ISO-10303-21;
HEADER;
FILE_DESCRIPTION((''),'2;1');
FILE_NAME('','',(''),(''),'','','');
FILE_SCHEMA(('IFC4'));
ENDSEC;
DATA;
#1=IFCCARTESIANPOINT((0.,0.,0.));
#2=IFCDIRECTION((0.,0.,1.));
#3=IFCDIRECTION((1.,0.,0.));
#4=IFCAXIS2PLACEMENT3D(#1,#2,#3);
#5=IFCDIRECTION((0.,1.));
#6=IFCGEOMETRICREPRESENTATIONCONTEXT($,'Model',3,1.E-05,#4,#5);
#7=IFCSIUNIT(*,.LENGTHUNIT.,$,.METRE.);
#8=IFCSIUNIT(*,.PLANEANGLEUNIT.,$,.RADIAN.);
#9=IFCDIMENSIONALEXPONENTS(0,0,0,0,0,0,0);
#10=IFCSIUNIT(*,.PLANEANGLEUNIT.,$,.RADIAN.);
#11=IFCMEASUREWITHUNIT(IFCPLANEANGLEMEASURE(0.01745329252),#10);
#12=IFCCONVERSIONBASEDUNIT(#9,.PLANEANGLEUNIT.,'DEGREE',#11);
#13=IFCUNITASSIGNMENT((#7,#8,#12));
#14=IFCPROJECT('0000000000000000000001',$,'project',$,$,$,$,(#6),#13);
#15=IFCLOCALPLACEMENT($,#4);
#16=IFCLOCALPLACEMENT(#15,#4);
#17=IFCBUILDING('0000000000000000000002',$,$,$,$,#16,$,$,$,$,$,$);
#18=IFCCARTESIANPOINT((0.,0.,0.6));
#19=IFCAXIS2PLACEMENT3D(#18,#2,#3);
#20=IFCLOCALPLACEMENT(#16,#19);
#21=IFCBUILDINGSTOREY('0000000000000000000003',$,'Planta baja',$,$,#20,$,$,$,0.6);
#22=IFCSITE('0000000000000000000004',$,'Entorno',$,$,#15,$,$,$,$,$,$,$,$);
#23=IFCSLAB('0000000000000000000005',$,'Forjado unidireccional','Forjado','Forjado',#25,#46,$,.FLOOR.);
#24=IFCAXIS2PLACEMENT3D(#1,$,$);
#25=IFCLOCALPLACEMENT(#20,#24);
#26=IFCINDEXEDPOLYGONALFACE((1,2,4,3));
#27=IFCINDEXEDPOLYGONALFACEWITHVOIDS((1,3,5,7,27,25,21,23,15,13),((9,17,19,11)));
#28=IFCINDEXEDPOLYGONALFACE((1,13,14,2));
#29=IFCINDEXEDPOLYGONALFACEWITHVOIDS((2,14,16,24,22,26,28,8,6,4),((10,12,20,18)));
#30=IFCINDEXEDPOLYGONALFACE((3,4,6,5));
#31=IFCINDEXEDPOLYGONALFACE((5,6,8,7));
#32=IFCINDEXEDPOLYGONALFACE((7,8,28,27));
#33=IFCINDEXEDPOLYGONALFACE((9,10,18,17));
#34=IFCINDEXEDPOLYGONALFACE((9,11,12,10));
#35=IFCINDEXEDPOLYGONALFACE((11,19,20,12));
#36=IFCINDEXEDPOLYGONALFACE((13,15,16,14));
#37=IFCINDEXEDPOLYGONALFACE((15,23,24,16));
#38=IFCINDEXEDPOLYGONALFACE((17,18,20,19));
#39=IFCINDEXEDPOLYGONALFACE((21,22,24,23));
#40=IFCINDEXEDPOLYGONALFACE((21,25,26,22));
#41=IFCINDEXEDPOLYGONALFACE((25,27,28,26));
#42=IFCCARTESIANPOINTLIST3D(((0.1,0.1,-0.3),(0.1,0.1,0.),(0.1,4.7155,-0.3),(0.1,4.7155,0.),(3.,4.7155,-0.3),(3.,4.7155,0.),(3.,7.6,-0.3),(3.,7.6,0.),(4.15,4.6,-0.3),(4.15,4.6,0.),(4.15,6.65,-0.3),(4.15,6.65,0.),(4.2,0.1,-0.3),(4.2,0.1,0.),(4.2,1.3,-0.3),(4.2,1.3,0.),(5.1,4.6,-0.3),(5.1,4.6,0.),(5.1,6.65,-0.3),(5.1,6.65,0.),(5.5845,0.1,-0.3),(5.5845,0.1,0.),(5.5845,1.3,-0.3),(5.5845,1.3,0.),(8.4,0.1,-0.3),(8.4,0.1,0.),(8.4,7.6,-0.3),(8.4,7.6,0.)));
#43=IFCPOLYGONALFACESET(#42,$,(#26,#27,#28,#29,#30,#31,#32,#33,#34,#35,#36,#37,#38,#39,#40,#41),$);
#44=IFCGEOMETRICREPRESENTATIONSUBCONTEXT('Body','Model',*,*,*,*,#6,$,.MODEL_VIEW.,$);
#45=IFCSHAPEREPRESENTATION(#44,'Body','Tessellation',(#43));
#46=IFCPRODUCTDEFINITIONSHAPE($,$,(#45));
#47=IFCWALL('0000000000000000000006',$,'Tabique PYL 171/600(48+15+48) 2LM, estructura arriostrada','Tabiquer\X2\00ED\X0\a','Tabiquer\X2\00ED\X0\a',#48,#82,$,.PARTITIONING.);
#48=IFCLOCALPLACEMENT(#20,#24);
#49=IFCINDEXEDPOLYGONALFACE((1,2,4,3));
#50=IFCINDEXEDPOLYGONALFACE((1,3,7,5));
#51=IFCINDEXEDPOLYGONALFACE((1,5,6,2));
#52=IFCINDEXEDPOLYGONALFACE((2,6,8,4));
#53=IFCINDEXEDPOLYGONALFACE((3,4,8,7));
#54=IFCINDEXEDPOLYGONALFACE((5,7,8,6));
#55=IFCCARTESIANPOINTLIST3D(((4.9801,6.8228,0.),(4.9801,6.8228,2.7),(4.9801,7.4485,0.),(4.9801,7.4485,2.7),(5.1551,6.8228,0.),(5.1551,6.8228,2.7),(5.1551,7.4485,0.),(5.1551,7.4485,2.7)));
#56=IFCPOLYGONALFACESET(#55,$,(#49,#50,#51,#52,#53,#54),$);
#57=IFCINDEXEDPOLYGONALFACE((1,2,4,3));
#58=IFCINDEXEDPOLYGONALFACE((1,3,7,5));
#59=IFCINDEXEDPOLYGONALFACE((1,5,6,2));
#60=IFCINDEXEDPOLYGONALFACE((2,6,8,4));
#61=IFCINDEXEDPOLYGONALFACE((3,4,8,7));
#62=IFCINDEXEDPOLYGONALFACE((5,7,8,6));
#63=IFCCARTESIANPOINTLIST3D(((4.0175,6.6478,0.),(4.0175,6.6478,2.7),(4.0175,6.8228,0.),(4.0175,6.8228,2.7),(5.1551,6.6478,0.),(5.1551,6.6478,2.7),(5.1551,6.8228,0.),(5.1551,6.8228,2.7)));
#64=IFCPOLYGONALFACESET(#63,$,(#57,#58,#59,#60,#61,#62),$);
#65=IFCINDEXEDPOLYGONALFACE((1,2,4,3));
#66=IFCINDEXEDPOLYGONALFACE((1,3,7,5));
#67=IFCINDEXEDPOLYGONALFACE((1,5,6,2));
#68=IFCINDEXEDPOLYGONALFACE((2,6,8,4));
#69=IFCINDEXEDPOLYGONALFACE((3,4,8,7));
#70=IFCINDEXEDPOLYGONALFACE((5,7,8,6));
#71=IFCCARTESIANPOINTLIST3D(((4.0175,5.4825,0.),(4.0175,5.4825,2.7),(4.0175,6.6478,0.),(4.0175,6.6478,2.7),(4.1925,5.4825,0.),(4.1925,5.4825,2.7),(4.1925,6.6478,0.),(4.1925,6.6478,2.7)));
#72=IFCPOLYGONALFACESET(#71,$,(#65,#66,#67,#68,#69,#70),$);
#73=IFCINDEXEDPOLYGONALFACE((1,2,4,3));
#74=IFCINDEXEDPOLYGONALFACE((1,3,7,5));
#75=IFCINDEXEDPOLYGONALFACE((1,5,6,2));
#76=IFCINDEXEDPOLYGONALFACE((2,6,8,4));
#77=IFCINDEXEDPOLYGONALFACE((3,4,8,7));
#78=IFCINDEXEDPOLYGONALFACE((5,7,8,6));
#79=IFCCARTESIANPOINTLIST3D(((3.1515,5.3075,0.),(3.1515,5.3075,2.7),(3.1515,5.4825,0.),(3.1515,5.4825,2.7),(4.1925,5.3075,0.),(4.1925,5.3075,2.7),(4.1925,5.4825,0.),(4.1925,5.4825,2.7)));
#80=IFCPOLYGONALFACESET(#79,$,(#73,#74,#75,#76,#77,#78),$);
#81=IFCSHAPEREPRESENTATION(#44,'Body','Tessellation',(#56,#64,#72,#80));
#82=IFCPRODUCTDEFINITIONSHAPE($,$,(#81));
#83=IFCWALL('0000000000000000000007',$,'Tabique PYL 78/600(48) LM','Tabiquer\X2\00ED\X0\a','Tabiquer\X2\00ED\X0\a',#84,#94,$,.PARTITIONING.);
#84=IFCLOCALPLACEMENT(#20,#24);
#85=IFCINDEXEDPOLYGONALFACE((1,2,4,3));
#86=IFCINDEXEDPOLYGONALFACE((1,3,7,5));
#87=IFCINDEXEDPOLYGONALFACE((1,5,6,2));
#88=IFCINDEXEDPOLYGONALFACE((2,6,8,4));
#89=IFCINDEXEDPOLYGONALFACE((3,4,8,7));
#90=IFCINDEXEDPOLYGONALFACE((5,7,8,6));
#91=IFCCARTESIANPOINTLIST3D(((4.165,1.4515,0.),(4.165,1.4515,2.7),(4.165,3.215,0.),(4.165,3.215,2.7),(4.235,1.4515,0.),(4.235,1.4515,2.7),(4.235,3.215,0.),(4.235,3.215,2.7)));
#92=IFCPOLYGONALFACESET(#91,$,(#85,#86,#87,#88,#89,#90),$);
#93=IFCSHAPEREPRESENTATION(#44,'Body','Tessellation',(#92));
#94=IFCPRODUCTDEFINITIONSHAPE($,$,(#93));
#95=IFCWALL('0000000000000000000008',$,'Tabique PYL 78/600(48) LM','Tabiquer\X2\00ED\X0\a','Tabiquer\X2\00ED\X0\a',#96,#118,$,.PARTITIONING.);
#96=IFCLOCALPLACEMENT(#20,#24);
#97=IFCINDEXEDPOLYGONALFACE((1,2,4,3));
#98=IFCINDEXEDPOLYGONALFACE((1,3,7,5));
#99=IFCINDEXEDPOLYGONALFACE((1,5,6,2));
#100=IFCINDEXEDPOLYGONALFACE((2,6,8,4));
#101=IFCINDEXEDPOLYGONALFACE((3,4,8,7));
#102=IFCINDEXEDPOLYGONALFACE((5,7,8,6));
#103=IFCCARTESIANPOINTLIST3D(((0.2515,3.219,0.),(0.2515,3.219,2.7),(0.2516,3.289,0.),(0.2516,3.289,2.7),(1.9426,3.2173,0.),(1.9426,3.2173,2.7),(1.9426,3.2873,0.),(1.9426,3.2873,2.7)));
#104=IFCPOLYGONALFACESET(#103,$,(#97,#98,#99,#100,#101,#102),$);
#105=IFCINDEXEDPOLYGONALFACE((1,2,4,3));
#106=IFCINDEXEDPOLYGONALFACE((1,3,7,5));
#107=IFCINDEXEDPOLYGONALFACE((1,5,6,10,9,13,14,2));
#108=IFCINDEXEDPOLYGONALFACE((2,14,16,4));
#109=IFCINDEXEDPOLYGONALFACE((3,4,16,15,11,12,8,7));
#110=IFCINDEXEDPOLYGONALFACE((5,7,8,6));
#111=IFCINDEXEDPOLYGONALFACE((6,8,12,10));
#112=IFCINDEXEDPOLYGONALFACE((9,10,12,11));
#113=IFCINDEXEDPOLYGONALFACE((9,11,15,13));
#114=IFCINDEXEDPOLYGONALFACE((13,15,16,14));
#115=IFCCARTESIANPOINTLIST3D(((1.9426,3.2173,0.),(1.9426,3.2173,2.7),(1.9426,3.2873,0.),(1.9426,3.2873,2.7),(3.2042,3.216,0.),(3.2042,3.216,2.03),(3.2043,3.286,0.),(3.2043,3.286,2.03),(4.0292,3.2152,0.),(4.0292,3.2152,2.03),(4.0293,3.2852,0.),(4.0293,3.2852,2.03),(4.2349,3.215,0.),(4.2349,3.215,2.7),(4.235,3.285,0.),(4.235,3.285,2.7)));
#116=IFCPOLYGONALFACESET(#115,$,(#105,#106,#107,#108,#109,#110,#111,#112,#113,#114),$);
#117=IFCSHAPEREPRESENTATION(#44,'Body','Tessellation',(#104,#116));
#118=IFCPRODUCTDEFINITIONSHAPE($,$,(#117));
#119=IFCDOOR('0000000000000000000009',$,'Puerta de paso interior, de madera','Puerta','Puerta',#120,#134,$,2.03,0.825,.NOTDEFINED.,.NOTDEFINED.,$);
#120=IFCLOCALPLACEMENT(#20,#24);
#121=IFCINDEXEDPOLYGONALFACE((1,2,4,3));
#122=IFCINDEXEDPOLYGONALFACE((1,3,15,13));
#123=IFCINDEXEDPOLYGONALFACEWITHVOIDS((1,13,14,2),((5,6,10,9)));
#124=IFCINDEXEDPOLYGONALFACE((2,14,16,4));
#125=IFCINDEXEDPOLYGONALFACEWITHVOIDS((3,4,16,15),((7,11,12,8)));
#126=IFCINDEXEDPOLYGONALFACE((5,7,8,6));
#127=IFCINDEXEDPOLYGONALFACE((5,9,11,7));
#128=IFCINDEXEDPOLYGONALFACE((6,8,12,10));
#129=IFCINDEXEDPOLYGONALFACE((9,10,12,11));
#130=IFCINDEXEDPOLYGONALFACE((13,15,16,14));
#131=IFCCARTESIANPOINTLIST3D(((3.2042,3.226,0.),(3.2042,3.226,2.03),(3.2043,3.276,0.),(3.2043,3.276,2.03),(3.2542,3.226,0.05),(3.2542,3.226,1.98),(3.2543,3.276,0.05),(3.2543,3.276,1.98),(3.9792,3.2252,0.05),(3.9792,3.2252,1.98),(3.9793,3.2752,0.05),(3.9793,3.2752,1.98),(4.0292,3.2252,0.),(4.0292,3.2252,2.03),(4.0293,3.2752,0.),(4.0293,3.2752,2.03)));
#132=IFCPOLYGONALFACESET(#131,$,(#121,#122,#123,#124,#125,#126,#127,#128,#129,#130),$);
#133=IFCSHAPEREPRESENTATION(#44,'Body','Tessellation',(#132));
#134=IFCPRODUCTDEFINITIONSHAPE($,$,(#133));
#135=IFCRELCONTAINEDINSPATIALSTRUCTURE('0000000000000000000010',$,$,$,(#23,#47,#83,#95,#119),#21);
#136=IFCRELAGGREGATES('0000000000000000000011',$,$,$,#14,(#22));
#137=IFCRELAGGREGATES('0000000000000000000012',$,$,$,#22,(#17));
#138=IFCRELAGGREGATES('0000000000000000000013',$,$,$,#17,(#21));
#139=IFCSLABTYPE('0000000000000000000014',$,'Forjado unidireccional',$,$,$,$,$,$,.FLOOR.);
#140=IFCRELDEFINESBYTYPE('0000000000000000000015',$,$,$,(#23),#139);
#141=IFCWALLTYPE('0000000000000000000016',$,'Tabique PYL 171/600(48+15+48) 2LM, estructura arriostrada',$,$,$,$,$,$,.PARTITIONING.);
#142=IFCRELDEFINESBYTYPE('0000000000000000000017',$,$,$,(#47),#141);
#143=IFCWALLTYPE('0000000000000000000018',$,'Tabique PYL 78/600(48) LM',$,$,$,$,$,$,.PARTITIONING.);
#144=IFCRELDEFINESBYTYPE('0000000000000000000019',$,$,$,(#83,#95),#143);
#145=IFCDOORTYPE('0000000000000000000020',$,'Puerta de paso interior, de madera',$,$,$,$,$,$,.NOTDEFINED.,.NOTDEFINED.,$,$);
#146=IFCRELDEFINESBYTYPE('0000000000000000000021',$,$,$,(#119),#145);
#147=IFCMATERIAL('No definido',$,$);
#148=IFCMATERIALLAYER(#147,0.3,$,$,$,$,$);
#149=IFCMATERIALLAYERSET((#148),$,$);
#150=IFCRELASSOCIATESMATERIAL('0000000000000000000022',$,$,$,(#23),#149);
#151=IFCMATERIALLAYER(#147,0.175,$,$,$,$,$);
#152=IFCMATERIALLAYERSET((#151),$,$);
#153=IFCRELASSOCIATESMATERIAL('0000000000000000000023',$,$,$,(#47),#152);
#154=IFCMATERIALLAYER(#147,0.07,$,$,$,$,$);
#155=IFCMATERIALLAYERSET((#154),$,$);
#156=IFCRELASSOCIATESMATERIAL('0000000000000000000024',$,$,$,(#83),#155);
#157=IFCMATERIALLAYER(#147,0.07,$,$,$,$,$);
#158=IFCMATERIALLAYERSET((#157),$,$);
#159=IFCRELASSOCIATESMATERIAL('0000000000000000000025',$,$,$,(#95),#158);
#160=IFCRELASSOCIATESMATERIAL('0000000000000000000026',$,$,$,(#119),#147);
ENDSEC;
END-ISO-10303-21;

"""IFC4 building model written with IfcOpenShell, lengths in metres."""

from ifc_helpers import new_model, entity, si_unit, converted_unit, direction, frame, origin_with_axes, origin_2d_with_axis, place, context, subcontext, project, spatial, polyline, rectangle, hollow_rectangle, outline, extrude, shape, material, layer, layer_set, layer_usage, type_object, element, fill, save


model = new_model("IFC4")

# Units and contexts
model_context = context("Model", 3, precision=1e-05, world=origin_with_axes(), true_north=direction((0.0, 1.0)))
body_context = subcontext(model_context, "Body", "Model", "MODEL_VIEW")
footprint_context = subcontext(model_context, "FootPrint", "Model", "MODEL_VIEW")
ifc_project = project(units=[si_unit("LENGTHUNIT", "METRE"), si_unit("PLANEANGLEUNIT", "RADIAN"), converted_unit("PLANEANGLEUNIT", "DEGREE", entity("IfcPlaneAngleMeasure", 0.01745329252), si_unit("PLANEANGLEUNIT", "RADIAN"), dimensions=[0, 0, 0, 0, 0, 0, 0])], contexts=[model_context])

# Site, building, storey
site_placement = place(None, origin_with_axes())
site = spatial("IfcSite", under=ifc_project, at=site_placement, Name="Entorno")
building_placement = place(site_placement, origin_with_axes())
building = spatial("IfcBuilding", under=site, at=building_placement)
storey_placement = place(building_placement, frame((0.0, 0.0, 0.6), z_axis=(0.0, 0.0, 1.0), x_axis=(1.0, 0.0, 0.0)))
storey = spatial("IfcBuildingStorey", under=building, at=storey_placement, Name="Planta baja", Elevation=0.6)

# Slab, opening
ifc_material = material(Name="No definido")
ifc_layer_1 = layer(ifc_material, 0.3)
ifc_layer_set_1 = layer_set([ifc_layer_1])
ifc_layer_usage_1 = layer_usage(ifc_layer_set_1, "AXIS3", "POSITIVE", 0.0)
slab_type_1 = type_object("IfcSlabType", Name="Forjado unidireccional", PredefinedType="FLOOR")
slab_placement = place(storey_placement, frame((4.2, 0.1, -0.3), z_axis=(0.0, 0.0, 1.0), x_axis=(1.0, 0.0, 0.0)))
slab = element("IfcSlab", 1, at=slab_placement, inside=storey, type_object=slab_type_1, material=ifc_layer_usage_1, Name="Forjado unidireccional", Description="Forjado", ObjectType="Forjado", PredefinedType="FLOOR", context=body_context, shape_type="SweptSolid", body=[
    extrude(outline(polyline([(0.0, 0.0), (0.0, 1.2), (1.3845, 1.2), (1.3845, 0.0), (4.2, 0.0), (4.2, 7.5), (-1.2, 7.5), (-1.2, 4.6155), (-4.1, 4.6155), (-4.1, 0.0), (0.0, 0.0)])), origin_with_axes(), (0.0, 0.0, 1.0), 0.3),
])
opening_1_placement = place(slab_placement, frame((-0.05, 4.5, -0.01), z_axis=(0.0, 0.0, 1.0), x_axis=(1.0, 0.0, 0.0)))
element("IfcOpeningElement", 2, at=opening_1_placement, cuts=slab, ObjectType="No definido", PredefinedType="OPENING", context=body_context, shape_type="SweptSolid", body=[
    extrude(outline(polyline([(0.0, 0.0), (0.95, 0.0), (0.95, 2.05), (0.0, 2.05), (0.0, 0.0)])), origin_with_axes(), (0.0, 0.0, 1.0), 0.32),
])

# Walls
ifc_layer_2 = layer(ifc_material, 0.175)
ifc_layer_set_2 = layer_set([ifc_layer_2])
ifc_layer_usage_2 = layer_usage(ifc_layer_set_2, "AXIS2", "POSITIVE", -0.0875)
wall_type_1 = type_object("IfcWallType", Name="Tabique PYL 171/600(48+15+48) 2LM, estructura arriostrada", PredefinedType="PARTITIONING")
wall_1_placement = place(storey_placement, frame((5.0676, 7.6, 0.0), z_axis=(0.0, 0.0, 1.0), x_axis=(0.0, -1.0, 0.0)))
cartesian_point_1 = entity("IfcCartesianPoint", [-0.3129, -1.35])
cartesian_point_2 = entity("IfcCartesianPoint", [-0.3129, -1.35])
cartesian_point_3 = entity("IfcCartesianPoint", [-0.5688, -1.35])
cartesian_point_4 = entity("IfcCartesianPoint", [-0.5688, -1.35])
cartesian_point_5 = entity("IfcCartesianPoint", [-0.5827, -1.35])
cartesian_point_6 = entity("IfcCartesianPoint", [-0.5827, -1.35])
cartesian_point_7 = entity("IfcCartesianPoint", [-0.5205, -1.35])
cartesian_point_8 = entity("IfcCartesianPoint", [-0.5205, -1.35])
element("IfcWall", 3, at=wall_1_placement, inside=storey, type_object=wall_type_1, material=ifc_layer_usage_2, Name="Tabique PYL 171/600(48+15+48) 2LM, estructura arriostrada", Description="Tabiquería", ObjectType="Tabiquería", PredefinedType="PARTITIONING", context=body_context, shape_type="SolidModel", body=[
    entity("IfcExtrudedAreaSolidTapered", entity("IfcArbitraryClosedProfileDef", "AREA", None, entity("IfcPolyline", [cartesian_point_1, entity("IfcCartesianPoint", [0.3129, -1.35]), entity("IfcCartesianPoint", [0.3129, 1.35]), entity("IfcCartesianPoint", [-0.3129, 1.35]), cartesian_point_1])), entity("IfcAxis2Placement3D", entity("IfcCartesianPoint", [0.4643, 0.0875, 1.35]), entity("IfcDirection", [0.0, -1.0, 0.0]), entity("IfcDirection", [1.0, 0.0, 0.0])), entity("IfcDirection", [0.0, 0.0, 1.0]), 0.175, entity("IfcArbitraryClosedProfileDef", "AREA", None, entity("IfcPolyline", [cartesian_point_2, entity("IfcCartesianPoint", [0.3129, -1.35]), entity("IfcCartesianPoint", [0.3129, 1.35]), entity("IfcCartesianPoint", [-0.3129, 1.35]), cartesian_point_2]))),
    entity("IfcExtrudedAreaSolidTapered", entity("IfcArbitraryClosedProfileDef", "AREA", None, entity("IfcPolyline", [cartesian_point_3, entity("IfcCartesianPoint", [0.5688, -1.35]), entity("IfcCartesianPoint", [0.5688, 1.35]), entity("IfcCartesianPoint", [-0.5688, 1.35]), cartesian_point_3])), entity("IfcAxis2Placement3D", entity("IfcCartesianPoint", [0.9522, -0.4813, 1.35]), entity("IfcDirection", [-1.0, 0.0, 0.0]), entity("IfcDirection", [0.0, -1.0, 0.0])), entity("IfcDirection", [0.0, 0.0, 1.0]), 0.175, entity("IfcArbitraryClosedProfileDef", "AREA", None, entity("IfcPolyline", [cartesian_point_4, entity("IfcCartesianPoint", [0.5688, -1.35]), entity("IfcCartesianPoint", [0.5688, 1.35]), entity("IfcCartesianPoint", [-0.5688, 1.35]), cartesian_point_4]))),
    entity("IfcExtrudedAreaSolidTapered", entity("IfcArbitraryClosedProfileDef", "AREA", None, entity("IfcPolyline", [cartesian_point_5, entity("IfcCartesianPoint", [0.5827, -1.35]), entity("IfcCartesianPoint", [0.5827, 1.35]), entity("IfcCartesianPoint", [-0.5827, 1.35]), cartesian_point_5])), entity("IfcAxis2Placement3D", entity("IfcCartesianPoint", [1.5349, -0.8751, 1.35]), entity("IfcDirection", [0.0, -1.0, 0.0]), entity("IfcDirection", [1.0, 0.0, 0.0])), entity("IfcDirection", [0.0, 0.0, 1.0]), 0.175, entity("IfcArbitraryClosedProfileDef", "AREA", None, entity("IfcPolyline", [cartesian_point_6, entity("IfcCartesianPoint", [0.5827, -1.35]), entity("IfcCartesianPoint", [0.5827, 1.35]), entity("IfcCartesianPoint", [-0.5827, 1.35]), cartesian_point_6]))),
    entity("IfcExtrudedAreaSolidTapered", entity("IfcArbitraryClosedProfileDef", "AREA", None, entity("IfcPolyline", [cartesian_point_7, entity("IfcCartesianPoint", [0.5205, -1.35]), entity("IfcCartesianPoint", [0.5205, 1.35]), entity("IfcCartesianPoint", [-0.5205, 1.35]), cartesian_point_7])), entity("IfcAxis2Placement3D", entity("IfcCartesianPoint", [2.2925, -1.3956, 1.35]), entity("IfcDirection", [-1.0, 0.0, 0.0]), entity("IfcDirection", [0.0, -1.0, 0.0])), entity("IfcDirection", [0.0, 0.0, 1.0]), 0.175, entity("IfcArbitraryClosedProfileDef", "AREA", None, entity("IfcPolyline", [cartesian_point_8, entity("IfcCartesianPoint", [0.5205, -1.35]), entity("IfcCartesianPoint", [0.5205, 1.35]), entity("IfcCartesianPoint", [-0.5205, 1.35]), cartesian_point_8]))),
])
ifc_layer_3 = layer(ifc_material, 0.07)
ifc_layer_set_3 = layer_set([ifc_layer_3])
ifc_layer_usage_3 = layer_usage(ifc_layer_set_3, "AXIS2", "POSITIVE", -0.035)
wall_type_2 = type_object("IfcWallType", Name="Tabique PYL 78/600(48) LM", PredefinedType="PARTITIONING")
wall_2_placement = place(storey_placement, frame((4.2, 1.3, 0.0), z_axis=(0.0, 0.0, 1.0), x_axis=(0.0, 1.0, 0.0)))
cartesian_point_9 = entity("IfcCartesianPoint", [-0.8817, -1.35])
cartesian_point_10 = entity("IfcCartesianPoint", [-0.8817, -1.35])
element("IfcWall", 4, at=wall_2_placement, inside=storey, type_object=wall_type_2, material=ifc_layer_usage_3, Name="Tabique PYL 78/600(48) LM", Description="Tabiquería", ObjectType="Tabiquería", PredefinedType="PARTITIONING", context=body_context, shape_type="SolidModel", body=[
    entity("IfcExtrudedAreaSolidTapered", entity("IfcArbitraryClosedProfileDef", "AREA", None, entity("IfcPolyline", [cartesian_point_9, entity("IfcCartesianPoint", [0.8817, -1.35]), entity("IfcCartesianPoint", [0.8817, 1.35]), entity("IfcCartesianPoint", [-0.8817, 1.35]), cartesian_point_9])), entity("IfcAxis2Placement3D", entity("IfcCartesianPoint", [1.0332, 0.035, 1.35]), entity("IfcDirection", [0.0, -1.0, 0.0]), entity("IfcDirection", [1.0, 0.0, 0.0])), entity("IfcDirection", [0.0, 0.0, 1.0]), 0.07, entity("IfcArbitraryClosedProfileDef", "AREA", None, entity("IfcPolyline", [cartesian_point_10, entity("IfcCartesianPoint", [0.8817, -1.35]), entity("IfcCartesianPoint", [0.8817, 1.35]), entity("IfcCartesianPoint", [-0.8817, 1.35]), cartesian_point_10]))),
])

# Wall, opening, door
ifc_layer_4 = layer(ifc_material, 0.07)
ifc_layer_set_4 = layer_set([ifc_layer_4])
ifc_layer_usage_4 = layer_usage(ifc_layer_set_4, "AXIS2", "POSITIVE", -0.035)
wall_3_placement = place(storey_placement, frame((0.1, 3.2542, 0.0), z_axis=(0.0, 0.0, 1.0), x_axis=(0.999999, -0.001016, 0.0)))
cartesian_point_11 = entity("IfcCartesianPoint", [-0.8455, -1.35])
cartesian_point_12 = entity("IfcCartesianPoint", [-0.8455, -1.35])
cartesian_point_13 = entity("IfcCartesianPoint", [-1.1462, -1.35])
cartesian_point_14 = entity("IfcCartesianPoint", [-1.1462, -1.35])
wall_3 = element("IfcWall", 5, at=wall_3_placement, inside=storey, type_object=wall_type_2, material=ifc_layer_usage_4, Name="Tabique PYL 78/600(48) LM", Description="Tabiquería", ObjectType="Tabiquería", PredefinedType="PARTITIONING", context=body_context, shape_type="SolidModel", body=[
    entity("IfcExtrudedAreaSolidTapered", entity("IfcArbitraryClosedProfileDef", "AREA", None, entity("IfcPolyline", [cartesian_point_11, entity("IfcCartesianPoint", [0.8455, -1.35]), entity("IfcCartesianPoint", [0.8455, 1.35]), entity("IfcCartesianPoint", [-0.8455, 1.35]), cartesian_point_11])), entity("IfcAxis2Placement3D", entity("IfcCartesianPoint", [0.9971, 0.035, 1.35]), entity("IfcDirection", [0.0, -1.0, 0.0]), entity("IfcDirection", [1.0, 0.0, 0.0])), entity("IfcDirection", [0.0, 0.0, 1.0]), 0.07, entity("IfcArbitraryClosedProfileDef", "AREA", None, entity("IfcPolyline", [cartesian_point_12, entity("IfcCartesianPoint", [0.8455, -1.35]), entity("IfcCartesianPoint", [0.8455, 1.35]), entity("IfcCartesianPoint", [-0.8455, 1.35]), cartesian_point_12]))),
    entity("IfcExtrudedAreaSolidTapered", entity("IfcArbitraryClosedProfileDef", "AREA", None, entity("IfcPolyline", [cartesian_point_13, entity("IfcCartesianPoint", [1.1462, -1.35]), entity("IfcCartesianPoint", [1.1462, 1.35]), entity("IfcCartesianPoint", [-1.1462, 1.35]), cartesian_point_13])), entity("IfcAxis2Placement3D", entity("IfcCartesianPoint", [2.9888, 0.035, 1.35]), entity("IfcDirection", [0.0, -1.0, 0.0]), entity("IfcDirection", [1.0, 0.0, 0.0])), entity("IfcDirection", [0.0, 0.0, 1.0]), 0.07, entity("IfcArbitraryClosedProfileDef", "AREA", None, entity("IfcPolyline", [cartesian_point_14, entity("IfcCartesianPoint", [1.1462, -1.35]), entity("IfcCartesianPoint", [1.1462, 1.35]), entity("IfcCartesianPoint", [-1.1462, 1.35]), cartesian_point_14]))),
])
opening_2_placement = place(wall_3_placement, frame((3.5168, 0.0, 1.015), z_axis=(0.0, 0.0, 1.0), x_axis=(1.0, 0.0, 0.0)))
cartesian_point_15 = entity("IfcCartesianPoint", [-0.4125, -0.035])
opening_2 = element("IfcOpeningElement", 6, at=opening_2_placement, cuts=wall_3, ObjectType="No definido", PredefinedType="OPENING", shapes=[
    shape(body_context, "Body", "SweptSolid", [extrude(rectangle(XDim=2.03, YDim=0.825, at=origin_2d_with_axis()), frame((0.0, -0.035, 0.0), z_axis=(0.0, 1.0, 0.0), x_axis=(0.0, 0.0, 1.0)), (0.0, 0.0, 1.0), 0.07)]),
    shape(footprint_context, "FootPrint", "GeometricCurveSet", [entity("IfcGeometricCurveSet", [entity("IfcPolyline", [cartesian_point_15, entity("IfcCartesianPoint", [0.4125, -0.035]), entity("IfcCartesianPoint", [0.4125, 0.035]), entity("IfcCartesianPoint", [-0.4125, 0.035]), cartesian_point_15])])]),
])
door_type_1 = type_object("IfcDoorType", Name="Puerta de paso interior, de madera", OperationType="NOTDEFINED", PredefinedType="NOTDEFINED")
door_1_placement = place(opening_2_placement, origin_with_axes())
door_1 = element("IfcDoor", 7, at=door_1_placement, inside=storey, type_object=door_type_1, material=ifc_material, Name="Puerta de paso interior, de madera", Description="Puerta", ObjectType="Puerta", OperationType="NOTDEFINED", OverallHeight=2.03, OverallWidth=0.825, PredefinedType="NOTDEFINED", context=body_context, shape_type="SweptSolid", body=[
    extrude(hollow_rectangle(XDim=0.825, YDim=2.03, WallThickness=0.05, InnerFilletRadius=0.0, OuterFilletRadius=0.0, at=origin_2d_with_axis()), frame((0.0, 0.025, 0.0), z_axis=(0.0, -1.0, 0.0), x_axis=(1.0, 0.0, 0.0)), (0.0, 0.0, 1.0), 0.05),
])
fill(opening_2, door_1)

save(model, "model.ifc")
